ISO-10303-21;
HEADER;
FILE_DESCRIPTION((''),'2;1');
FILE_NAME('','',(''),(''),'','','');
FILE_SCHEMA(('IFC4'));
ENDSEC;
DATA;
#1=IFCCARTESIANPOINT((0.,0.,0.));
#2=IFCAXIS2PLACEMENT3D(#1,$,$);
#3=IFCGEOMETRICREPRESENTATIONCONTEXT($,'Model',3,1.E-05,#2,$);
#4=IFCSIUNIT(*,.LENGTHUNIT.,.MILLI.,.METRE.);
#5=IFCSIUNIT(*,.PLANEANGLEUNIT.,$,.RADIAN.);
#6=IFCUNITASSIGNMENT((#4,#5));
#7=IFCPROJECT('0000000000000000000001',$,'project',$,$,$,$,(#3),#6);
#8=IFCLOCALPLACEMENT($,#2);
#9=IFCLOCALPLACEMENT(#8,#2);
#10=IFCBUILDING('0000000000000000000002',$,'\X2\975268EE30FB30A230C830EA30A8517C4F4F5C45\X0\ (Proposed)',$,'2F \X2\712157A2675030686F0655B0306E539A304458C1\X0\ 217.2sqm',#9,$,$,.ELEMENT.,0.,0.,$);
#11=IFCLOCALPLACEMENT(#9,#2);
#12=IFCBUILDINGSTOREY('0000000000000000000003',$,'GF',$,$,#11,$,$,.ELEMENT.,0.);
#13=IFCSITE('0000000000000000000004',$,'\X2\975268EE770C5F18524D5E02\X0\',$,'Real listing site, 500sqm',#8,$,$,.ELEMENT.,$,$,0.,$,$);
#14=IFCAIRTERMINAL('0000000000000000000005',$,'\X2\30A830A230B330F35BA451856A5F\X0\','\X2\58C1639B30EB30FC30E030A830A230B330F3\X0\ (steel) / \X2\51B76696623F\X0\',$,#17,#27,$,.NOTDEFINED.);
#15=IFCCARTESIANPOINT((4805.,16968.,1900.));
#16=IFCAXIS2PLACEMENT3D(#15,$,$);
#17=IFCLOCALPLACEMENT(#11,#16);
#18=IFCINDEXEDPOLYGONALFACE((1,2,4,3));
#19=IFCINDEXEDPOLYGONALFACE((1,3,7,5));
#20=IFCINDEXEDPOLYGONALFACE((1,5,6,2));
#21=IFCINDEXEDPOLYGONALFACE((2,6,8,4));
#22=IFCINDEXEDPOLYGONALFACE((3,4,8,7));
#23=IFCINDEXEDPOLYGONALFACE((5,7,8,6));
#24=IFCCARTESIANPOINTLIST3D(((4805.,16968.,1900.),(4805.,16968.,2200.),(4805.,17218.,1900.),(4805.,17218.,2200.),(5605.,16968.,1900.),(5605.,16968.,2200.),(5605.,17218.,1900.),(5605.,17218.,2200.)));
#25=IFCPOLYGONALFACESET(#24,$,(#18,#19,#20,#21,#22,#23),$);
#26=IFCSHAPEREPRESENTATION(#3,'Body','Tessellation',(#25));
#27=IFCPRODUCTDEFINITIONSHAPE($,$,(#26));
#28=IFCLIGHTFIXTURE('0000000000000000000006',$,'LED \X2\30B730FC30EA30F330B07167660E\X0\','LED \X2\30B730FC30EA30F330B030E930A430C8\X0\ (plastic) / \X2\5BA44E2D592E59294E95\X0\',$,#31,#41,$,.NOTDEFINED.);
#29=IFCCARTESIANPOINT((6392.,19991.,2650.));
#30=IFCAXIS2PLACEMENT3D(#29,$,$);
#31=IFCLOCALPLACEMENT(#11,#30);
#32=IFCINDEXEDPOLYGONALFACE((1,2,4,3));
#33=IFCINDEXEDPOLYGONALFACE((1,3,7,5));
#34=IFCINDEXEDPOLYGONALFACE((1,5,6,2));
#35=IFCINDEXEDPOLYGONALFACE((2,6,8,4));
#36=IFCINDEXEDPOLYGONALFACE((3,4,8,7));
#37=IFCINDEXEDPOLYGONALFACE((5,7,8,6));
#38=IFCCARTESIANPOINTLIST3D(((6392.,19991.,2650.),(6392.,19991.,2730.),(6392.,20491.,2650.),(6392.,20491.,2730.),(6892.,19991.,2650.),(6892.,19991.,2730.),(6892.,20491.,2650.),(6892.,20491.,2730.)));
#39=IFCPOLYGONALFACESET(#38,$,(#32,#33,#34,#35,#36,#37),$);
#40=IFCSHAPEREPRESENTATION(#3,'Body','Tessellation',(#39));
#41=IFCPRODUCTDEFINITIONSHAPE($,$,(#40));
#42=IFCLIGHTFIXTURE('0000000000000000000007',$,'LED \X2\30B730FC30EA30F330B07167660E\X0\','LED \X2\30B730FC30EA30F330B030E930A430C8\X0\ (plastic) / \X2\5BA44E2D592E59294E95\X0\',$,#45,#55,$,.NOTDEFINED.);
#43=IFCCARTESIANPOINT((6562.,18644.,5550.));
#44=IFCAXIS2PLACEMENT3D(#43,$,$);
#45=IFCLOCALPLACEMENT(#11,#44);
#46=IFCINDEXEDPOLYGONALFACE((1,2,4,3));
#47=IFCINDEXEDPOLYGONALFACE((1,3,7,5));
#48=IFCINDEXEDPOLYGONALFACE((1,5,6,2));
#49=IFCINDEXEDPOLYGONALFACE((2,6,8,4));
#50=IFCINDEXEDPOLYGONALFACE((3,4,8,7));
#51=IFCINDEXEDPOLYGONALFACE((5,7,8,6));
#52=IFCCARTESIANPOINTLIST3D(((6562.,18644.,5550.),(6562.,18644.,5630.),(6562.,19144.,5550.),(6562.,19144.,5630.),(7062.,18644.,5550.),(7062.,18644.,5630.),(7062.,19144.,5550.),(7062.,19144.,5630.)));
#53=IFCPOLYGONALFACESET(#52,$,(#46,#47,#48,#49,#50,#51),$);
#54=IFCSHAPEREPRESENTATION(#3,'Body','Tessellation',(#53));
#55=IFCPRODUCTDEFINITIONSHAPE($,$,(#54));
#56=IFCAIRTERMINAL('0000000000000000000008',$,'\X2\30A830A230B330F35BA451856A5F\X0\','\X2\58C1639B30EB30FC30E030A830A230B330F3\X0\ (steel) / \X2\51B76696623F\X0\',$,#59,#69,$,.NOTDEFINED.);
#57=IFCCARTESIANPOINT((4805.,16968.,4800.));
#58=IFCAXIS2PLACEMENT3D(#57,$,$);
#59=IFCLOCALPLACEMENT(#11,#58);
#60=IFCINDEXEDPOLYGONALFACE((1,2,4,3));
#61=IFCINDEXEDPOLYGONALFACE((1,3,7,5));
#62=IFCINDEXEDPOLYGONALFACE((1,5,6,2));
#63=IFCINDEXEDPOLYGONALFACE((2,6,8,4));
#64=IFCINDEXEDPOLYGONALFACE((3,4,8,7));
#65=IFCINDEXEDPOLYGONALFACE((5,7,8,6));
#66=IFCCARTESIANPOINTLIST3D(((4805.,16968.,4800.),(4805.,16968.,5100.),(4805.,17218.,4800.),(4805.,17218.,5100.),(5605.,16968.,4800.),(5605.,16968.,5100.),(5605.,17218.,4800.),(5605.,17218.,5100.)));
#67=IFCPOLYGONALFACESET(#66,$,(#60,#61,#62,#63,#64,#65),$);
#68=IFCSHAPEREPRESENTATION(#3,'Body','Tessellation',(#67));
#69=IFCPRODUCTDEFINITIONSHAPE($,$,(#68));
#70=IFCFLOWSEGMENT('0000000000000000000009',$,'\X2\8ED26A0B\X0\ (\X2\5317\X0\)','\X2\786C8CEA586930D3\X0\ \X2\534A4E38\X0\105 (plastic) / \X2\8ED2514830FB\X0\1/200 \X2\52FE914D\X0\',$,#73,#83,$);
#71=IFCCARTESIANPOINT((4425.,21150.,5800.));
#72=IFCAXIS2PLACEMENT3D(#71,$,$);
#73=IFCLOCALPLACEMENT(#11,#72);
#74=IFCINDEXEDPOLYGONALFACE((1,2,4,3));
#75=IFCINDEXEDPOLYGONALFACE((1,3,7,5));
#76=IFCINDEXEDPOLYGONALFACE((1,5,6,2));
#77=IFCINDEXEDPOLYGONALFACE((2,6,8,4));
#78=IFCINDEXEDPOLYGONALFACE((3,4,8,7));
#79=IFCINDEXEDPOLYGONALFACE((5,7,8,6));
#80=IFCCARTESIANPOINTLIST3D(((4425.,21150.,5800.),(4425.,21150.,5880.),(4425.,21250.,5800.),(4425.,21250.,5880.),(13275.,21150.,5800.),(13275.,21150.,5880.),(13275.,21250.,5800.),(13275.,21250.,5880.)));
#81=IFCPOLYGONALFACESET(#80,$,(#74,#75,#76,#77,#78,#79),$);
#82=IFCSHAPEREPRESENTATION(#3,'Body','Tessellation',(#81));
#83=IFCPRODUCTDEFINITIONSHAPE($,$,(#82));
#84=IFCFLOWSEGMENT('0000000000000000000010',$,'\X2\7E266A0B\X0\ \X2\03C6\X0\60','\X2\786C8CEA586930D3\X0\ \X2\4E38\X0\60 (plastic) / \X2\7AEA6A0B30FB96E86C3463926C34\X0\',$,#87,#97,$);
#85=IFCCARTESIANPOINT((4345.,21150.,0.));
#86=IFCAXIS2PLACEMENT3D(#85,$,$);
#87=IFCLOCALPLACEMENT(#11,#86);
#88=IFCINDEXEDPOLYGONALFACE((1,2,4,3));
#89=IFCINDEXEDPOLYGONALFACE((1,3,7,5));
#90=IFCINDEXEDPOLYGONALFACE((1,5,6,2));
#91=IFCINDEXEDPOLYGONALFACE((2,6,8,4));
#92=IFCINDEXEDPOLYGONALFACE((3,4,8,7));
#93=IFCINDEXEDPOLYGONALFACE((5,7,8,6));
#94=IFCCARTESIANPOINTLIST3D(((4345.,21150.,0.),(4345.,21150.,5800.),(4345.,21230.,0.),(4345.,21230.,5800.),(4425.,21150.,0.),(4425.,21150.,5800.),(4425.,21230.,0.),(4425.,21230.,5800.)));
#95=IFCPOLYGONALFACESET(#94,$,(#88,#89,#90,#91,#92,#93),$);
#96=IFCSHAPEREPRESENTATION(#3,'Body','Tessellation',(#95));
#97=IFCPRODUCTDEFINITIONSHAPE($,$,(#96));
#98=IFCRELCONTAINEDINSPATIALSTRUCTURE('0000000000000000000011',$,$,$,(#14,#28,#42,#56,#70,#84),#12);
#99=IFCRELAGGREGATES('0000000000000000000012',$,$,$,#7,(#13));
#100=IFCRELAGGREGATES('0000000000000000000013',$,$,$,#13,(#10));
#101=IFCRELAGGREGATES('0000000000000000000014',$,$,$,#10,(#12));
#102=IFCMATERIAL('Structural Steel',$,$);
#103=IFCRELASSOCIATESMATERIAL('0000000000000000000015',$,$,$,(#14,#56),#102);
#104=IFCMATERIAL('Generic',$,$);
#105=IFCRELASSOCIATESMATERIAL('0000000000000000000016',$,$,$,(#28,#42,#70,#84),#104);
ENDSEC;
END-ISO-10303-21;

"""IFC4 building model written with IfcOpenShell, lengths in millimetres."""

from ifc_helpers import new_model, si_unit, frame, frame_2d, origin, place, context, project, spatial, rectangle, extrude, material, element, save


model = new_model("IFC4")

# Units and contexts
model_context = context("Model", 3, precision=1e-05, world=origin())
ifc_project = project(units=[si_unit("LENGTHUNIT", "METRE", prefix="MILLI"), si_unit("PLANEANGLEUNIT", "RADIAN")], contexts=[model_context])

# Site, building, storey
site_placement = place(None, origin())
site = spatial("IfcSite", under=ifc_project, at=site_placement, Name="青森県弘前市", ObjectType="Real listing site, 500sqm", CompositionType="ELEMENT", RefElevation=0.0)
building_placement = place(site_placement, origin())
building = spatial("IfcBuilding", under=site, at=building_placement, Name="青森・アトリエ兼住居 (Proposed)", ObjectType="2F 無垢材と漆喰の厚い壁 217.2sqm", CompositionType="ELEMENT", ElevationOfRefHeight=0.0, ElevationOfTerrain=0.0)
storey_placement = place(building_placement, origin())
storey = spatial("IfcBuildingStorey", under=building, at=storey_placement, Name="GF", CompositionType="ELEMENT", Elevation=0.0)

# Shared definitions
ifc_material_1 = material(Name="Generic")

# Shared definitions
ifc_material_2 = material(Name="Structural Steel")

# Air terminal
air_terminal_1_placement = place(storey_placement, frame((4805.0, 16968.0, 1900.0)))
element("IfcAirTerminal", 1, at=air_terminal_1_placement, inside=storey, material=ifc_material_2, Name="エアコン室内機", Description="壁掛ルームエアコン (steel) / 冷暖房", PredefinedType="NOTDEFINED", context=model_context, shape_type="SweptSolid", body=[
    extrude(rectangle(XDim=800.0, YDim=250.0, at=frame_2d((400.0, 125.0))), frame((4805.0, 16968.0, 1900.0)), (0.0, 0.0, 1.0), 300.0),
])

# Light fixtures
light_fixture_1_placement = place(storey_placement, frame((6392.0, 19991.0, 2650.0)))
element("IfcLightFixture", 2, at=light_fixture_1_placement, inside=storey, material=ifc_material_1, Name="LED シーリング照明", Description="LED シーリングライト (plastic) / 室中央天井", PredefinedType="NOTDEFINED", context=model_context, shape_type="SweptSolid", body=[
    extrude(rectangle(XDim=500.0, YDim=500.0, at=frame_2d((250.0, 250.0))), frame((6392.0, 19991.0, 2650.0)), (0.0, 0.0, 1.0), 80.0),
])
light_fixture_2_placement = place(storey_placement, frame((6562.0, 18644.0, 5550.0)))
element("IfcLightFixture", 3, at=light_fixture_2_placement, inside=storey, material=ifc_material_1, Name="LED シーリング照明", Description="LED シーリングライト (plastic) / 室中央天井", PredefinedType="NOTDEFINED", context=model_context, shape_type="SweptSolid", body=[
    extrude(rectangle(XDim=500.0, YDim=500.0, at=frame_2d((250.0, 250.0))), frame((6562.0, 18644.0, 5550.0)), (0.0, 0.0, 1.0), 80.0),
])

# Air terminal
air_terminal_2_placement = place(storey_placement, frame((4805.0, 16968.0, 4800.0)))
element("IfcAirTerminal", 4, at=air_terminal_2_placement, inside=storey, material=ifc_material_2, Name="エアコン室内機", Description="壁掛ルームエアコン (steel) / 冷暖房", PredefinedType="NOTDEFINED", context=model_context, shape_type="SweptSolid", body=[
    extrude(rectangle(XDim=800.0, YDim=250.0, at=frame_2d((400.0, 125.0))), frame((4805.0, 16968.0, 4800.0)), (0.0, 0.0, 1.0), 300.0),
])

# Flow segments
flow_segment_1_placement = place(storey_placement, frame((4425.0, 21150.0, 5800.0)))
element("IfcFlowSegment", 5, at=flow_segment_1_placement, inside=storey, material=ifc_material_1, Name="軒樋 (北)", Description="硬質塩ビ 半丸105 (plastic) / 軒先・1/200 勾配", context=model_context, shape_type="SweptSolid", body=[
    extrude(rectangle(XDim=8850.0, YDim=100.0, at=frame_2d((4425.0, 50.0))), frame((4425.0, 21150.0, 5800.0)), (0.0, 0.0, 1.0), 80.0),
])
flow_segment_2_placement = place(storey_placement, frame((4345.0, 21150.0, 0.0)))
element("IfcFlowSegment", 6, at=flow_segment_2_placement, inside=storey, material=ifc_material_1, Name="縦樋 φ60", Description="硬質塩ビ 丸60 (plastic) / 竪樋・雨水排水", context=model_context, shape_type="SweptSolid", body=[
    extrude(rectangle(XDim=80.0, YDim=80.0, at=frame_2d((40.0, 40.0))), frame((4345.0, 21150.0, 0.0)), (0.0, 0.0, 1.0), 5800.0),
])

save(model, "model.ifc")
